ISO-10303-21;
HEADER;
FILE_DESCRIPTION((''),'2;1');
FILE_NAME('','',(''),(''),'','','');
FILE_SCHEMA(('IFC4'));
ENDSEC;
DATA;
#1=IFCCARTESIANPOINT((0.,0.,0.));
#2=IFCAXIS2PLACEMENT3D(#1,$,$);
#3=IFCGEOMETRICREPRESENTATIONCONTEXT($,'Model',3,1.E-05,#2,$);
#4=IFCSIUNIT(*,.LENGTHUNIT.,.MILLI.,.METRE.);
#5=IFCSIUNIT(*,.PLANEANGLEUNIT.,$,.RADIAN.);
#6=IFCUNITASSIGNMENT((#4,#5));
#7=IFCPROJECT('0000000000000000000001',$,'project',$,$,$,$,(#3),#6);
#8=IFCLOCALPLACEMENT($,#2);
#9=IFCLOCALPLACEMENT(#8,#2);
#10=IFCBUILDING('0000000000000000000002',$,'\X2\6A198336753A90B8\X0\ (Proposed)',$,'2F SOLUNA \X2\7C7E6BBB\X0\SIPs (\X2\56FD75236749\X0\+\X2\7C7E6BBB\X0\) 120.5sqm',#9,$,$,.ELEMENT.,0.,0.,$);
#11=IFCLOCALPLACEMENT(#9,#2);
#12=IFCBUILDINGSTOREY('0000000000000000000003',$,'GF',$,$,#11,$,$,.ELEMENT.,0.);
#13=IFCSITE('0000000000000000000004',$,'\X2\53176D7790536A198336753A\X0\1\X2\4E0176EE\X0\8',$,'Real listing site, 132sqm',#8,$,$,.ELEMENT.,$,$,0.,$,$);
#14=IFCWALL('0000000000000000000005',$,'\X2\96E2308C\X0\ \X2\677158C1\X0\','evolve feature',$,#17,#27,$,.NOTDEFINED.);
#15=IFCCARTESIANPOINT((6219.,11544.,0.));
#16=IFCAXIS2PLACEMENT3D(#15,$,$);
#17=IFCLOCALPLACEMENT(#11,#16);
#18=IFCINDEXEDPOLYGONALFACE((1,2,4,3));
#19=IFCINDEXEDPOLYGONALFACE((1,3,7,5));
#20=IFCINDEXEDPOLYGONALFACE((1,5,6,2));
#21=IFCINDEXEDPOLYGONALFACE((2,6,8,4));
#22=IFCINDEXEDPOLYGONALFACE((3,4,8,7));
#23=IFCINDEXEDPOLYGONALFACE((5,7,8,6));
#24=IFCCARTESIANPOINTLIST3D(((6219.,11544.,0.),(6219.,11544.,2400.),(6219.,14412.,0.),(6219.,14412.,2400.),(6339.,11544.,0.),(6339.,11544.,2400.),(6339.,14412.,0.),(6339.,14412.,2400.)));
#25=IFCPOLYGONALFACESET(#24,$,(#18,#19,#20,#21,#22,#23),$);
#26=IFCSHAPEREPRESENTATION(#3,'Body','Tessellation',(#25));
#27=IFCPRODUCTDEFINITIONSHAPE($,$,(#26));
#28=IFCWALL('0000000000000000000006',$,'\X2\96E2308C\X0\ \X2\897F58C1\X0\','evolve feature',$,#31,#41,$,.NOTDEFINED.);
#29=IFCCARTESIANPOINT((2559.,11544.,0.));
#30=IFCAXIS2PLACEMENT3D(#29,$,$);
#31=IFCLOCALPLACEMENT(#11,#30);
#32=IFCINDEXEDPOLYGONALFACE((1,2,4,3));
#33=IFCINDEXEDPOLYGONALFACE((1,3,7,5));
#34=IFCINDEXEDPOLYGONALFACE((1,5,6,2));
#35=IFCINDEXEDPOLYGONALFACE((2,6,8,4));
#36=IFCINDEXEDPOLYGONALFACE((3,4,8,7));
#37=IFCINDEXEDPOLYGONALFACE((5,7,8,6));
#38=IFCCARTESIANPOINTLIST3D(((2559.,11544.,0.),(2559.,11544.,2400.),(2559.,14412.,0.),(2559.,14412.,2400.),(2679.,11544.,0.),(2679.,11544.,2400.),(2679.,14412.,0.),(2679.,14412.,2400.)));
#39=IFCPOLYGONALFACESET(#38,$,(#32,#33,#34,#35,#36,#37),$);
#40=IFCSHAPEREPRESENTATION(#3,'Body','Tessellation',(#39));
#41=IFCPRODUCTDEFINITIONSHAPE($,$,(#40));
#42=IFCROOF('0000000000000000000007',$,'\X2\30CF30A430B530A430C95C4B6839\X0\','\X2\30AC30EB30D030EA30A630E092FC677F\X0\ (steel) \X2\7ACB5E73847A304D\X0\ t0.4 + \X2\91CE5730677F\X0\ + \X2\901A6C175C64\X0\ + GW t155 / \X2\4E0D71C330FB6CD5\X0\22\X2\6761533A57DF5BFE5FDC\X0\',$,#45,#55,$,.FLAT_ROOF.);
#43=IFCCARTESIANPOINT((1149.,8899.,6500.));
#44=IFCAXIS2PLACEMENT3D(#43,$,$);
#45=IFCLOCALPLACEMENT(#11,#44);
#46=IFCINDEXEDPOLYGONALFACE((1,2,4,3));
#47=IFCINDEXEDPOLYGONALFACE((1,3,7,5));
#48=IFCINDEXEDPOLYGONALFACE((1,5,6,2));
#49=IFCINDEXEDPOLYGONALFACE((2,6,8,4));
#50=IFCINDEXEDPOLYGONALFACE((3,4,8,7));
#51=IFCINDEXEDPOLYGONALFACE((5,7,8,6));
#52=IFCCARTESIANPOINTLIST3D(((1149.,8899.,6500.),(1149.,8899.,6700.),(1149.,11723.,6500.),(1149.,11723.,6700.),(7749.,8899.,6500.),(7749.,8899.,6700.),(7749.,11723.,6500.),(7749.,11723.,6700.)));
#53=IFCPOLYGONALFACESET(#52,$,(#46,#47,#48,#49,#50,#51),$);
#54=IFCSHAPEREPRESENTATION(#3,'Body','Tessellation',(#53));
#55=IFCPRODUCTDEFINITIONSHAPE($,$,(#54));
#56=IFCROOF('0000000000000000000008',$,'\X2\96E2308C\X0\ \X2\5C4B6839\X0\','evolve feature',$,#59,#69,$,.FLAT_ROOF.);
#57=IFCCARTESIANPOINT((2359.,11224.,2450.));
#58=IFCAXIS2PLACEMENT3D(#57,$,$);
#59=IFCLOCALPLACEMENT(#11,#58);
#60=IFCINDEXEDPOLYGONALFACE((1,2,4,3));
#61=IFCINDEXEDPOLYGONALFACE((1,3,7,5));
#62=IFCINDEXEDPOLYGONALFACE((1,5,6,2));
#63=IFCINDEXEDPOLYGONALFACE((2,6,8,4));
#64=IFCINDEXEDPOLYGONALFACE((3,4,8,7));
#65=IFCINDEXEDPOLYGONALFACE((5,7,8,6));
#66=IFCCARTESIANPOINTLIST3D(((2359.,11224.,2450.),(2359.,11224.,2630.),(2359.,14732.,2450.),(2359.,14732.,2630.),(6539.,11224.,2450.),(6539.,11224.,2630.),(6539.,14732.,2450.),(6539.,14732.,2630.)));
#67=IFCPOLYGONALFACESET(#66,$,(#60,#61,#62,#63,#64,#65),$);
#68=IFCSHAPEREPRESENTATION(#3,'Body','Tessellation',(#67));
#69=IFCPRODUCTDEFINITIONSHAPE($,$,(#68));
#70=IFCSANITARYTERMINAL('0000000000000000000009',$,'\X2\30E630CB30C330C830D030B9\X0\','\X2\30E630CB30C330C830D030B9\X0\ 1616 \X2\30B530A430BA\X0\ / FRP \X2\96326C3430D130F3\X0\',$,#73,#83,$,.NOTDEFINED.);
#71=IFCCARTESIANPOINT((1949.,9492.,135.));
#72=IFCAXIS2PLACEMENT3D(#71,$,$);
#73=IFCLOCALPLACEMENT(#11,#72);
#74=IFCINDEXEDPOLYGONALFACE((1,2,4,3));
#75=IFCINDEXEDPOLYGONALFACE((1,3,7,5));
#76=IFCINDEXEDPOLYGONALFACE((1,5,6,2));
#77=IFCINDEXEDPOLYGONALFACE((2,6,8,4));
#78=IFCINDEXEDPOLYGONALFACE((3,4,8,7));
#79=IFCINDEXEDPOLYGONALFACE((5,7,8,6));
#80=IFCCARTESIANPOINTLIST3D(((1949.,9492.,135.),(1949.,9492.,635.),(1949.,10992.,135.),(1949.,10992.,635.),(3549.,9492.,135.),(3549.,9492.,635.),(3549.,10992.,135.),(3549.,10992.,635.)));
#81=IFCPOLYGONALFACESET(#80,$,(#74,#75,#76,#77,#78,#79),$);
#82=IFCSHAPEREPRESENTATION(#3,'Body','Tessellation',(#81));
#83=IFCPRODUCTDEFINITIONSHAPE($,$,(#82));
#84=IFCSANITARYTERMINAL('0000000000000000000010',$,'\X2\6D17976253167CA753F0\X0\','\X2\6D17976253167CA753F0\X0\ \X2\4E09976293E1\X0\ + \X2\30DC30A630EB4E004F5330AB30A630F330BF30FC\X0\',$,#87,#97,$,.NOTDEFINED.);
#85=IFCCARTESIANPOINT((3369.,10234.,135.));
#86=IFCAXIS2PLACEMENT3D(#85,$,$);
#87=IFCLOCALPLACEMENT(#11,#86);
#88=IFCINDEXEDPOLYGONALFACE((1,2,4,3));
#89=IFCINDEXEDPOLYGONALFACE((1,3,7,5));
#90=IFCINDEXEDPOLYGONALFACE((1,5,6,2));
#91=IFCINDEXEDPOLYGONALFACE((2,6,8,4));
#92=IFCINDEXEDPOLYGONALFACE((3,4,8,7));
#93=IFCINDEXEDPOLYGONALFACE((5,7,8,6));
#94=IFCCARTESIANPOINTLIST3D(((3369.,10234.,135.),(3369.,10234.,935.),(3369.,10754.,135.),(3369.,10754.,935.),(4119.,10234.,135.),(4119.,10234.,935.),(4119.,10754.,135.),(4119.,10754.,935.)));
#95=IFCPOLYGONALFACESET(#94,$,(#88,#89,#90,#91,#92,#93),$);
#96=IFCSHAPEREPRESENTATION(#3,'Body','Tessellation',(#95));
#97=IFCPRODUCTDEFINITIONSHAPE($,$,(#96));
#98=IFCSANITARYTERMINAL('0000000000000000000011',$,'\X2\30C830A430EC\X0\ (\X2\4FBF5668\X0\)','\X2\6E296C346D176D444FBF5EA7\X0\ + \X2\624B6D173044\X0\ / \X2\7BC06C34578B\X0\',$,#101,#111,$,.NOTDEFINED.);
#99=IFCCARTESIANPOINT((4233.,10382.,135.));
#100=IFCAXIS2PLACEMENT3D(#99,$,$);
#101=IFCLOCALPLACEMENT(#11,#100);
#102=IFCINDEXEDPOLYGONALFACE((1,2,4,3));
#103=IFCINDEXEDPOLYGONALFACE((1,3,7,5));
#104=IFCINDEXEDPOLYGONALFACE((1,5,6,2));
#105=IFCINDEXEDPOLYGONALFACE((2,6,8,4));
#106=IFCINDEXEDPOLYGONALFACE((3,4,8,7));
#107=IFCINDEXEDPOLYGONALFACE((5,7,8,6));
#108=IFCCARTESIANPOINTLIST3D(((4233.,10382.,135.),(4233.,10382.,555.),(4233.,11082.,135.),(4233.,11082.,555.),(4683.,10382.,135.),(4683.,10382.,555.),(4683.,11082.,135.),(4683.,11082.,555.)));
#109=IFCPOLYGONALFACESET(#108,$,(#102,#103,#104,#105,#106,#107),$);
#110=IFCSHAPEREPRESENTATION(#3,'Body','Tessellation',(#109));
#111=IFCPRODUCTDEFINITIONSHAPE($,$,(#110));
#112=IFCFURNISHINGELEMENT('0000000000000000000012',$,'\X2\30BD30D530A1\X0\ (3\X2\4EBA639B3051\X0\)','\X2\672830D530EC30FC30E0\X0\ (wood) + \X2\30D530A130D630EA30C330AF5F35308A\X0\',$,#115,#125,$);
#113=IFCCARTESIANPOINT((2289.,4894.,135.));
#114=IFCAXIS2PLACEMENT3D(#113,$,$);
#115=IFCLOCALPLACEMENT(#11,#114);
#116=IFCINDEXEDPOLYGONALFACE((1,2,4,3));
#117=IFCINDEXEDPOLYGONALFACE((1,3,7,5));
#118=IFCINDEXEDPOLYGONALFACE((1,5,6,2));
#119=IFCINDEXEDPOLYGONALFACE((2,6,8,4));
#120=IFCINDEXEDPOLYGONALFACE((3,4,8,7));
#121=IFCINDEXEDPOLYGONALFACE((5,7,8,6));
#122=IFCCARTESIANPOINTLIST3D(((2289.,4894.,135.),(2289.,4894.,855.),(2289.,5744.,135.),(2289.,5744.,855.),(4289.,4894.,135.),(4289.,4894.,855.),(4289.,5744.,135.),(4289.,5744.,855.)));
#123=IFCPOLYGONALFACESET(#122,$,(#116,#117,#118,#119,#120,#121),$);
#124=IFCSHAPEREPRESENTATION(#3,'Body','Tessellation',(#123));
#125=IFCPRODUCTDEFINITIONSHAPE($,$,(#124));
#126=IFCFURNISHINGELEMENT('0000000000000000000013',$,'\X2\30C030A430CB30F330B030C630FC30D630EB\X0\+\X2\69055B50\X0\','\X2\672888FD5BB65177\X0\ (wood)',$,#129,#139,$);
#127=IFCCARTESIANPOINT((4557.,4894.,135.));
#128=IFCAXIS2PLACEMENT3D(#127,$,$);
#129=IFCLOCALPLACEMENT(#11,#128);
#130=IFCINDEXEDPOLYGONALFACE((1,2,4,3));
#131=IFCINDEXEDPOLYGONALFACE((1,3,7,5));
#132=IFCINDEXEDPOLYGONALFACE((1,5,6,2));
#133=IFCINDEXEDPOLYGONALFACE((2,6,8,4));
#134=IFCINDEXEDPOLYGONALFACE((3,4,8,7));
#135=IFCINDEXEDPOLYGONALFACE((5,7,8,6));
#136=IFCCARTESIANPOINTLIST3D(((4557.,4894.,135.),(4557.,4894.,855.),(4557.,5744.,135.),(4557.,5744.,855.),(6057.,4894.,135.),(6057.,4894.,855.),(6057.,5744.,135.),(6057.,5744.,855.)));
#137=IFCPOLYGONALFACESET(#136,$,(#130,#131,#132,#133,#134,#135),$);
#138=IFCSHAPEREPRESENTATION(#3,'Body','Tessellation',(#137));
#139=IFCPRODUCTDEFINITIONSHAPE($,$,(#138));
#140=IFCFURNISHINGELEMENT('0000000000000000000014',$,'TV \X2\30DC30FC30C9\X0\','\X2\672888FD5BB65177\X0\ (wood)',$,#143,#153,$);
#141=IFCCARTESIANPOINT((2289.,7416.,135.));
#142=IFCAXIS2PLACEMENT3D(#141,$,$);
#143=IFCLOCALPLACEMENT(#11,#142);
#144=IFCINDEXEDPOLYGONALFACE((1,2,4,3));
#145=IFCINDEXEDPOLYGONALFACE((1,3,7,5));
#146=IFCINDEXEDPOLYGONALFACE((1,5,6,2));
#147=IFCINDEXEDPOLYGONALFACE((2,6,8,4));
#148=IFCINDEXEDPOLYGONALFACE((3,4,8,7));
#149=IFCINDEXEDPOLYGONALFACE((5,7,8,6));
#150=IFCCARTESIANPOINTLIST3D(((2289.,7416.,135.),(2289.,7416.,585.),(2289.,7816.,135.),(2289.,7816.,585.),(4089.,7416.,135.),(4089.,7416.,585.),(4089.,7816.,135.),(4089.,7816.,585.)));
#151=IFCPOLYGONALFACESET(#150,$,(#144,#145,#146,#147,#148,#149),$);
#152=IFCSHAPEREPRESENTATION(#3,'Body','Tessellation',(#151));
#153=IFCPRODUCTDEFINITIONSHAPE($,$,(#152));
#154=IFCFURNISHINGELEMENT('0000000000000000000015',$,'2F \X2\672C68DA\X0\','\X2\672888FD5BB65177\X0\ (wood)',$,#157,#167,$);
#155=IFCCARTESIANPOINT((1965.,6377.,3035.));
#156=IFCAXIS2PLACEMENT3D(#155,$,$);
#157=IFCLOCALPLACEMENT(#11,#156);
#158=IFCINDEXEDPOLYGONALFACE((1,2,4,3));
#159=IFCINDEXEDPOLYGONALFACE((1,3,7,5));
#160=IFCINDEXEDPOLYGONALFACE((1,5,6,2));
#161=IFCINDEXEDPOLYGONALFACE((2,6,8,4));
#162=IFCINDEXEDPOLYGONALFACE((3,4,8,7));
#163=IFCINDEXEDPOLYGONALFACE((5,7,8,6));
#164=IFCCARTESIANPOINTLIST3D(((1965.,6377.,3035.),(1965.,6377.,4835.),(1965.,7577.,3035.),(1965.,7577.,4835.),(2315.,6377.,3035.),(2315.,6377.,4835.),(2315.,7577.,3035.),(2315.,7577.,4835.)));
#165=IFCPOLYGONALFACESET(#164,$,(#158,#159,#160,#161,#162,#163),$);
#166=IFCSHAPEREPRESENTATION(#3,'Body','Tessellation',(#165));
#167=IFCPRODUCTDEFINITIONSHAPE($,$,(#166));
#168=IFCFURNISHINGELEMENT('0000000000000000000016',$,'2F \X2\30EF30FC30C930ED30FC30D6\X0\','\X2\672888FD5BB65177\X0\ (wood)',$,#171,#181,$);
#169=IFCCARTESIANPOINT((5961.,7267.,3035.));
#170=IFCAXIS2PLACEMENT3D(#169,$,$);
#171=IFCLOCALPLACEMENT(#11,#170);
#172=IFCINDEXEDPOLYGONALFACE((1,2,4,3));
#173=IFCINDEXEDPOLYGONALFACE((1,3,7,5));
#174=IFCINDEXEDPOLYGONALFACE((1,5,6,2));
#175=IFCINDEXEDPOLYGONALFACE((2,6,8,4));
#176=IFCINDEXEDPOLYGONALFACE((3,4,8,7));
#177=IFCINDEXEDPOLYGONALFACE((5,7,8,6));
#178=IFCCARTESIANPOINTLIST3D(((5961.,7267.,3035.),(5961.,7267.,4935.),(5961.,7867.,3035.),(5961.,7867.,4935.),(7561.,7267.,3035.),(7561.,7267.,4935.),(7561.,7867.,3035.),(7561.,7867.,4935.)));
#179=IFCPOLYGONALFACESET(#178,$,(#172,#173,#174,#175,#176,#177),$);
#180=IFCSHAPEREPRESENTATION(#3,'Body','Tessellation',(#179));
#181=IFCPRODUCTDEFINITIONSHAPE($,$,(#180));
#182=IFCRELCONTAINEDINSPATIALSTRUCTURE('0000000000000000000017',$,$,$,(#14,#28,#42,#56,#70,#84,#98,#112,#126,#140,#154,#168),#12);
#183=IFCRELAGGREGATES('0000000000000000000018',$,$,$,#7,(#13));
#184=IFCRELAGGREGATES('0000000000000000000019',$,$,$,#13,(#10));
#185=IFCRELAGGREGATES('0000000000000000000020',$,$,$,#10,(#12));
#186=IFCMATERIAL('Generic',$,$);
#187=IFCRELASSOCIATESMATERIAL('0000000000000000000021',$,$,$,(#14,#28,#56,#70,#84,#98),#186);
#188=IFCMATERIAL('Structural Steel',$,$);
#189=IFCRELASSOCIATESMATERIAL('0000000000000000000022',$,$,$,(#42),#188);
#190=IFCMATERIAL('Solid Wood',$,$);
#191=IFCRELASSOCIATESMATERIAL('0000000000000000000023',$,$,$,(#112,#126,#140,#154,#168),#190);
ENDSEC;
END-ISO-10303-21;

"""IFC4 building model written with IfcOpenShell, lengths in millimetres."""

from ifc_helpers import new_model, si_unit, frame, frame_2d, origin, place, context, project, spatial, rectangle, extrude, material, element, save


model = new_model("IFC4")

# Units and contexts
model_context = context("Model", 3, precision=1e-05, world=origin())
ifc_project = project(units=[si_unit("LENGTHUNIT", "METRE", prefix="MILLI"), si_unit("PLANEANGLEUNIT", "RADIAN")], contexts=[model_context])

# Site, building, storey
site_placement = place(None, origin())
site = spatial("IfcSite", under=ifc_project, at=site_placement, Name="北海道標茶町1丁目8", ObjectType="Real listing site, 132sqm", CompositionType="ELEMENT", RefElevation=0.0)
building_placement = place(site_placement, origin())
building = spatial("IfcBuilding", under=site, at=building_placement, Name="標茶町邸 (Proposed)", ObjectType="2F SOLUNA 籾殻SIPs (国産杉+籾殻) 120.5sqm", CompositionType="ELEMENT", ElevationOfRefHeight=0.0, ElevationOfTerrain=0.0)
storey_placement = place(building_placement, origin())
storey = spatial("IfcBuildingStorey", under=building, at=storey_placement, Name="GF", CompositionType="ELEMENT", Elevation=0.0)

# Shared definitions
ifc_material_1 = material(Name="Generic")

# Shared definitions
ifc_material_2 = material(Name="Solid Wood")

# Walls
wall_1_placement = place(storey_placement, frame((6219.0, 11544.0, 0.0)))
element("IfcWall", 1, at=wall_1_placement, inside=storey, material=ifc_material_1, Name="離れ 東壁", Description="evolve feature", PredefinedType="NOTDEFINED", context=model_context, shape_type="SweptSolid", body=[
    extrude(rectangle(XDim=120.0, YDim=2868.0, at=frame_2d((60.0, 1434.0))), frame((6219.0, 11544.0, 0.0)), (0.0, 0.0, 1.0), 2400.0),
])
wall_2_placement = place(storey_placement, frame((2559.0, 11544.0, 0.0)))
element("IfcWall", 2, at=wall_2_placement, inside=storey, material=ifc_material_1, Name="離れ 西壁", Description="evolve feature", PredefinedType="NOTDEFINED", context=model_context, shape_type="SweptSolid", body=[
    extrude(rectangle(XDim=120.0, YDim=2868.0, at=frame_2d((60.0, 1434.0))), frame((2559.0, 11544.0, 0.0)), (0.0, 0.0, 1.0), 2400.0),
])

# Roofs
ifc_material_3 = material(Name="Structural Steel")
roof_1_placement = place(storey_placement, frame((1149.0, 8899.0, 6500.0)))
element("IfcRoof", 3, at=roof_1_placement, inside=storey, material=ifc_material_3, Name="ハイサイド屋根", Description="ガルバリウム鋼板 (steel) 立平葺き t0.4 + 野地板 + 通気層 + GW t155 / 不燃・法22条区域対応", PredefinedType="FLAT_ROOF", context=model_context, shape_type="SweptSolid", body=[
    extrude(rectangle(XDim=6600.0, YDim=2824.0, at=frame_2d((3300.0, 1412.0))), frame((1149.0, 8899.0, 6500.0)), (0.0, 0.0, 1.0), 200.0),
])
roof_2_placement = place(storey_placement, frame((2359.0, 11224.0, 2450.0)))
element("IfcRoof", 4, at=roof_2_placement, inside=storey, material=ifc_material_1, Name="離れ 屋根", Description="evolve feature", PredefinedType="FLAT_ROOF", context=model_context, shape_type="SweptSolid", body=[
    extrude(rectangle(XDim=4180.0, YDim=3508.0, at=frame_2d((2090.0, 1754.0))), frame((2359.0, 11224.0, 2450.0)), (0.0, 0.0, 1.0), 180.0),
])

# Sanitary terminals
sanitary_terminal_1_placement = place(storey_placement, frame((1949.0, 9492.0, 135.0)))
element("IfcSanitaryTerminal", 5, at=sanitary_terminal_1_placement, inside=storey, material=ifc_material_1, Name="ユニットバス", Description="ユニットバス 1616 サイズ / FRP 防水パン", PredefinedType="NOTDEFINED", context=model_context, shape_type="SweptSolid", body=[
    extrude(rectangle(XDim=1600.0, YDim=1500.0, at=frame_2d((800.0, 750.0))), frame((1949.0, 9492.0, 135.0)), (0.0, 0.0, 1.0), 500.0),
])
sanitary_terminal_2_placement = place(storey_placement, frame((3369.0, 10234.0, 135.0)))
element("IfcSanitaryTerminal", 6, at=sanitary_terminal_2_placement, inside=storey, material=ifc_material_1, Name="洗面化粧台", Description="洗面化粧台 三面鏡 + ボウル一体カウンター", PredefinedType="NOTDEFINED", context=model_context, shape_type="SweptSolid", body=[
    extrude(rectangle(XDim=750.0, YDim=520.0, at=frame_2d((375.0, 260.0))), frame((3369.0, 10234.0, 135.0)), (0.0, 0.0, 1.0), 800.0),
])
sanitary_terminal_3_placement = place(storey_placement, frame((4233.0, 10382.0, 135.0)))
element("IfcSanitaryTerminal", 7, at=sanitary_terminal_3_placement, inside=storey, material=ifc_material_1, Name="トイレ (便器)", Description="温水洗浄便座 + 手洗い / 節水型", PredefinedType="NOTDEFINED", context=model_context, shape_type="SweptSolid", body=[
    extrude(rectangle(XDim=450.0, YDim=700.0, at=frame_2d((225.0, 350.0))), frame((4233.0, 10382.0, 135.0)), (0.0, 0.0, 1.0), 420.0),
])

# Furnishing elements
furnishing_1_placement = place(storey_placement, frame((2289.0, 4894.0, 135.0)))
element("IfcFurnishingElement", 8, at=furnishing_1_placement, inside=storey, material=ifc_material_2, Name="ソファ (3人掛け)", Description="木フレーム (wood) + ファブリック張り", context=model_context, shape_type="SweptSolid", body=[
    extrude(rectangle(XDim=2000.0, YDim=850.0, at=frame_2d((1000.0, 425.0))), frame((2289.0, 4894.0, 135.0)), (0.0, 0.0, 1.0), 720.0),
])
furnishing_2_placement = place(storey_placement, frame((4557.0, 4894.0, 135.0)))
element("IfcFurnishingElement", 9, at=furnishing_2_placement, inside=storey, material=ifc_material_2, Name="ダイニングテーブル+椅子", Description="木製家具 (wood)", context=model_context, shape_type="SweptSolid", body=[
    extrude(rectangle(XDim=1500.0, YDim=850.0, at=frame_2d((750.0, 425.0))), frame((4557.0, 4894.0, 135.0)), (0.0, 0.0, 1.0), 720.0),
])
furnishing_3_placement = place(storey_placement, frame((2289.0, 7416.0, 135.0)))
element("IfcFurnishingElement", 10, at=furnishing_3_placement, inside=storey, material=ifc_material_2, Name="TV ボード", Description="木製家具 (wood)", context=model_context, shape_type="SweptSolid", body=[
    extrude(rectangle(XDim=1800.0, YDim=400.0, at=frame_2d((900.0, 200.0))), frame((2289.0, 7416.0, 135.0)), (0.0, 0.0, 1.0), 450.0),
])
furnishing_4_placement = place(storey_placement, frame((1965.0, 6377.0, 3035.0)))
element("IfcFurnishingElement", 11, at=furnishing_4_placement, inside=storey, material=ifc_material_2, Name="2F 本棚", Description="木製家具 (wood)", context=model_context, shape_type="SweptSolid", body=[
    extrude(rectangle(XDim=350.0, YDim=1200.0, at=frame_2d((175.0, 600.0))), frame((1965.0, 6377.0, 3035.0)), (0.0, 0.0, 1.0), 1800.0),
])
furnishing_5_placement = place(storey_placement, frame((5961.0, 7267.0, 3035.0)))
element("IfcFurnishingElement", 12, at=furnishing_5_placement, inside=storey, material=ifc_material_2, Name="2F ワードローブ", Description="木製家具 (wood)", context=model_context, shape_type="SweptSolid", body=[
    extrude(rectangle(XDim=1600.0, YDim=600.0, at=frame_2d((800.0, 300.0))), frame((5961.0, 7267.0, 3035.0)), (0.0, 0.0, 1.0), 1900.0),
])

save(model, "model.ifc")
